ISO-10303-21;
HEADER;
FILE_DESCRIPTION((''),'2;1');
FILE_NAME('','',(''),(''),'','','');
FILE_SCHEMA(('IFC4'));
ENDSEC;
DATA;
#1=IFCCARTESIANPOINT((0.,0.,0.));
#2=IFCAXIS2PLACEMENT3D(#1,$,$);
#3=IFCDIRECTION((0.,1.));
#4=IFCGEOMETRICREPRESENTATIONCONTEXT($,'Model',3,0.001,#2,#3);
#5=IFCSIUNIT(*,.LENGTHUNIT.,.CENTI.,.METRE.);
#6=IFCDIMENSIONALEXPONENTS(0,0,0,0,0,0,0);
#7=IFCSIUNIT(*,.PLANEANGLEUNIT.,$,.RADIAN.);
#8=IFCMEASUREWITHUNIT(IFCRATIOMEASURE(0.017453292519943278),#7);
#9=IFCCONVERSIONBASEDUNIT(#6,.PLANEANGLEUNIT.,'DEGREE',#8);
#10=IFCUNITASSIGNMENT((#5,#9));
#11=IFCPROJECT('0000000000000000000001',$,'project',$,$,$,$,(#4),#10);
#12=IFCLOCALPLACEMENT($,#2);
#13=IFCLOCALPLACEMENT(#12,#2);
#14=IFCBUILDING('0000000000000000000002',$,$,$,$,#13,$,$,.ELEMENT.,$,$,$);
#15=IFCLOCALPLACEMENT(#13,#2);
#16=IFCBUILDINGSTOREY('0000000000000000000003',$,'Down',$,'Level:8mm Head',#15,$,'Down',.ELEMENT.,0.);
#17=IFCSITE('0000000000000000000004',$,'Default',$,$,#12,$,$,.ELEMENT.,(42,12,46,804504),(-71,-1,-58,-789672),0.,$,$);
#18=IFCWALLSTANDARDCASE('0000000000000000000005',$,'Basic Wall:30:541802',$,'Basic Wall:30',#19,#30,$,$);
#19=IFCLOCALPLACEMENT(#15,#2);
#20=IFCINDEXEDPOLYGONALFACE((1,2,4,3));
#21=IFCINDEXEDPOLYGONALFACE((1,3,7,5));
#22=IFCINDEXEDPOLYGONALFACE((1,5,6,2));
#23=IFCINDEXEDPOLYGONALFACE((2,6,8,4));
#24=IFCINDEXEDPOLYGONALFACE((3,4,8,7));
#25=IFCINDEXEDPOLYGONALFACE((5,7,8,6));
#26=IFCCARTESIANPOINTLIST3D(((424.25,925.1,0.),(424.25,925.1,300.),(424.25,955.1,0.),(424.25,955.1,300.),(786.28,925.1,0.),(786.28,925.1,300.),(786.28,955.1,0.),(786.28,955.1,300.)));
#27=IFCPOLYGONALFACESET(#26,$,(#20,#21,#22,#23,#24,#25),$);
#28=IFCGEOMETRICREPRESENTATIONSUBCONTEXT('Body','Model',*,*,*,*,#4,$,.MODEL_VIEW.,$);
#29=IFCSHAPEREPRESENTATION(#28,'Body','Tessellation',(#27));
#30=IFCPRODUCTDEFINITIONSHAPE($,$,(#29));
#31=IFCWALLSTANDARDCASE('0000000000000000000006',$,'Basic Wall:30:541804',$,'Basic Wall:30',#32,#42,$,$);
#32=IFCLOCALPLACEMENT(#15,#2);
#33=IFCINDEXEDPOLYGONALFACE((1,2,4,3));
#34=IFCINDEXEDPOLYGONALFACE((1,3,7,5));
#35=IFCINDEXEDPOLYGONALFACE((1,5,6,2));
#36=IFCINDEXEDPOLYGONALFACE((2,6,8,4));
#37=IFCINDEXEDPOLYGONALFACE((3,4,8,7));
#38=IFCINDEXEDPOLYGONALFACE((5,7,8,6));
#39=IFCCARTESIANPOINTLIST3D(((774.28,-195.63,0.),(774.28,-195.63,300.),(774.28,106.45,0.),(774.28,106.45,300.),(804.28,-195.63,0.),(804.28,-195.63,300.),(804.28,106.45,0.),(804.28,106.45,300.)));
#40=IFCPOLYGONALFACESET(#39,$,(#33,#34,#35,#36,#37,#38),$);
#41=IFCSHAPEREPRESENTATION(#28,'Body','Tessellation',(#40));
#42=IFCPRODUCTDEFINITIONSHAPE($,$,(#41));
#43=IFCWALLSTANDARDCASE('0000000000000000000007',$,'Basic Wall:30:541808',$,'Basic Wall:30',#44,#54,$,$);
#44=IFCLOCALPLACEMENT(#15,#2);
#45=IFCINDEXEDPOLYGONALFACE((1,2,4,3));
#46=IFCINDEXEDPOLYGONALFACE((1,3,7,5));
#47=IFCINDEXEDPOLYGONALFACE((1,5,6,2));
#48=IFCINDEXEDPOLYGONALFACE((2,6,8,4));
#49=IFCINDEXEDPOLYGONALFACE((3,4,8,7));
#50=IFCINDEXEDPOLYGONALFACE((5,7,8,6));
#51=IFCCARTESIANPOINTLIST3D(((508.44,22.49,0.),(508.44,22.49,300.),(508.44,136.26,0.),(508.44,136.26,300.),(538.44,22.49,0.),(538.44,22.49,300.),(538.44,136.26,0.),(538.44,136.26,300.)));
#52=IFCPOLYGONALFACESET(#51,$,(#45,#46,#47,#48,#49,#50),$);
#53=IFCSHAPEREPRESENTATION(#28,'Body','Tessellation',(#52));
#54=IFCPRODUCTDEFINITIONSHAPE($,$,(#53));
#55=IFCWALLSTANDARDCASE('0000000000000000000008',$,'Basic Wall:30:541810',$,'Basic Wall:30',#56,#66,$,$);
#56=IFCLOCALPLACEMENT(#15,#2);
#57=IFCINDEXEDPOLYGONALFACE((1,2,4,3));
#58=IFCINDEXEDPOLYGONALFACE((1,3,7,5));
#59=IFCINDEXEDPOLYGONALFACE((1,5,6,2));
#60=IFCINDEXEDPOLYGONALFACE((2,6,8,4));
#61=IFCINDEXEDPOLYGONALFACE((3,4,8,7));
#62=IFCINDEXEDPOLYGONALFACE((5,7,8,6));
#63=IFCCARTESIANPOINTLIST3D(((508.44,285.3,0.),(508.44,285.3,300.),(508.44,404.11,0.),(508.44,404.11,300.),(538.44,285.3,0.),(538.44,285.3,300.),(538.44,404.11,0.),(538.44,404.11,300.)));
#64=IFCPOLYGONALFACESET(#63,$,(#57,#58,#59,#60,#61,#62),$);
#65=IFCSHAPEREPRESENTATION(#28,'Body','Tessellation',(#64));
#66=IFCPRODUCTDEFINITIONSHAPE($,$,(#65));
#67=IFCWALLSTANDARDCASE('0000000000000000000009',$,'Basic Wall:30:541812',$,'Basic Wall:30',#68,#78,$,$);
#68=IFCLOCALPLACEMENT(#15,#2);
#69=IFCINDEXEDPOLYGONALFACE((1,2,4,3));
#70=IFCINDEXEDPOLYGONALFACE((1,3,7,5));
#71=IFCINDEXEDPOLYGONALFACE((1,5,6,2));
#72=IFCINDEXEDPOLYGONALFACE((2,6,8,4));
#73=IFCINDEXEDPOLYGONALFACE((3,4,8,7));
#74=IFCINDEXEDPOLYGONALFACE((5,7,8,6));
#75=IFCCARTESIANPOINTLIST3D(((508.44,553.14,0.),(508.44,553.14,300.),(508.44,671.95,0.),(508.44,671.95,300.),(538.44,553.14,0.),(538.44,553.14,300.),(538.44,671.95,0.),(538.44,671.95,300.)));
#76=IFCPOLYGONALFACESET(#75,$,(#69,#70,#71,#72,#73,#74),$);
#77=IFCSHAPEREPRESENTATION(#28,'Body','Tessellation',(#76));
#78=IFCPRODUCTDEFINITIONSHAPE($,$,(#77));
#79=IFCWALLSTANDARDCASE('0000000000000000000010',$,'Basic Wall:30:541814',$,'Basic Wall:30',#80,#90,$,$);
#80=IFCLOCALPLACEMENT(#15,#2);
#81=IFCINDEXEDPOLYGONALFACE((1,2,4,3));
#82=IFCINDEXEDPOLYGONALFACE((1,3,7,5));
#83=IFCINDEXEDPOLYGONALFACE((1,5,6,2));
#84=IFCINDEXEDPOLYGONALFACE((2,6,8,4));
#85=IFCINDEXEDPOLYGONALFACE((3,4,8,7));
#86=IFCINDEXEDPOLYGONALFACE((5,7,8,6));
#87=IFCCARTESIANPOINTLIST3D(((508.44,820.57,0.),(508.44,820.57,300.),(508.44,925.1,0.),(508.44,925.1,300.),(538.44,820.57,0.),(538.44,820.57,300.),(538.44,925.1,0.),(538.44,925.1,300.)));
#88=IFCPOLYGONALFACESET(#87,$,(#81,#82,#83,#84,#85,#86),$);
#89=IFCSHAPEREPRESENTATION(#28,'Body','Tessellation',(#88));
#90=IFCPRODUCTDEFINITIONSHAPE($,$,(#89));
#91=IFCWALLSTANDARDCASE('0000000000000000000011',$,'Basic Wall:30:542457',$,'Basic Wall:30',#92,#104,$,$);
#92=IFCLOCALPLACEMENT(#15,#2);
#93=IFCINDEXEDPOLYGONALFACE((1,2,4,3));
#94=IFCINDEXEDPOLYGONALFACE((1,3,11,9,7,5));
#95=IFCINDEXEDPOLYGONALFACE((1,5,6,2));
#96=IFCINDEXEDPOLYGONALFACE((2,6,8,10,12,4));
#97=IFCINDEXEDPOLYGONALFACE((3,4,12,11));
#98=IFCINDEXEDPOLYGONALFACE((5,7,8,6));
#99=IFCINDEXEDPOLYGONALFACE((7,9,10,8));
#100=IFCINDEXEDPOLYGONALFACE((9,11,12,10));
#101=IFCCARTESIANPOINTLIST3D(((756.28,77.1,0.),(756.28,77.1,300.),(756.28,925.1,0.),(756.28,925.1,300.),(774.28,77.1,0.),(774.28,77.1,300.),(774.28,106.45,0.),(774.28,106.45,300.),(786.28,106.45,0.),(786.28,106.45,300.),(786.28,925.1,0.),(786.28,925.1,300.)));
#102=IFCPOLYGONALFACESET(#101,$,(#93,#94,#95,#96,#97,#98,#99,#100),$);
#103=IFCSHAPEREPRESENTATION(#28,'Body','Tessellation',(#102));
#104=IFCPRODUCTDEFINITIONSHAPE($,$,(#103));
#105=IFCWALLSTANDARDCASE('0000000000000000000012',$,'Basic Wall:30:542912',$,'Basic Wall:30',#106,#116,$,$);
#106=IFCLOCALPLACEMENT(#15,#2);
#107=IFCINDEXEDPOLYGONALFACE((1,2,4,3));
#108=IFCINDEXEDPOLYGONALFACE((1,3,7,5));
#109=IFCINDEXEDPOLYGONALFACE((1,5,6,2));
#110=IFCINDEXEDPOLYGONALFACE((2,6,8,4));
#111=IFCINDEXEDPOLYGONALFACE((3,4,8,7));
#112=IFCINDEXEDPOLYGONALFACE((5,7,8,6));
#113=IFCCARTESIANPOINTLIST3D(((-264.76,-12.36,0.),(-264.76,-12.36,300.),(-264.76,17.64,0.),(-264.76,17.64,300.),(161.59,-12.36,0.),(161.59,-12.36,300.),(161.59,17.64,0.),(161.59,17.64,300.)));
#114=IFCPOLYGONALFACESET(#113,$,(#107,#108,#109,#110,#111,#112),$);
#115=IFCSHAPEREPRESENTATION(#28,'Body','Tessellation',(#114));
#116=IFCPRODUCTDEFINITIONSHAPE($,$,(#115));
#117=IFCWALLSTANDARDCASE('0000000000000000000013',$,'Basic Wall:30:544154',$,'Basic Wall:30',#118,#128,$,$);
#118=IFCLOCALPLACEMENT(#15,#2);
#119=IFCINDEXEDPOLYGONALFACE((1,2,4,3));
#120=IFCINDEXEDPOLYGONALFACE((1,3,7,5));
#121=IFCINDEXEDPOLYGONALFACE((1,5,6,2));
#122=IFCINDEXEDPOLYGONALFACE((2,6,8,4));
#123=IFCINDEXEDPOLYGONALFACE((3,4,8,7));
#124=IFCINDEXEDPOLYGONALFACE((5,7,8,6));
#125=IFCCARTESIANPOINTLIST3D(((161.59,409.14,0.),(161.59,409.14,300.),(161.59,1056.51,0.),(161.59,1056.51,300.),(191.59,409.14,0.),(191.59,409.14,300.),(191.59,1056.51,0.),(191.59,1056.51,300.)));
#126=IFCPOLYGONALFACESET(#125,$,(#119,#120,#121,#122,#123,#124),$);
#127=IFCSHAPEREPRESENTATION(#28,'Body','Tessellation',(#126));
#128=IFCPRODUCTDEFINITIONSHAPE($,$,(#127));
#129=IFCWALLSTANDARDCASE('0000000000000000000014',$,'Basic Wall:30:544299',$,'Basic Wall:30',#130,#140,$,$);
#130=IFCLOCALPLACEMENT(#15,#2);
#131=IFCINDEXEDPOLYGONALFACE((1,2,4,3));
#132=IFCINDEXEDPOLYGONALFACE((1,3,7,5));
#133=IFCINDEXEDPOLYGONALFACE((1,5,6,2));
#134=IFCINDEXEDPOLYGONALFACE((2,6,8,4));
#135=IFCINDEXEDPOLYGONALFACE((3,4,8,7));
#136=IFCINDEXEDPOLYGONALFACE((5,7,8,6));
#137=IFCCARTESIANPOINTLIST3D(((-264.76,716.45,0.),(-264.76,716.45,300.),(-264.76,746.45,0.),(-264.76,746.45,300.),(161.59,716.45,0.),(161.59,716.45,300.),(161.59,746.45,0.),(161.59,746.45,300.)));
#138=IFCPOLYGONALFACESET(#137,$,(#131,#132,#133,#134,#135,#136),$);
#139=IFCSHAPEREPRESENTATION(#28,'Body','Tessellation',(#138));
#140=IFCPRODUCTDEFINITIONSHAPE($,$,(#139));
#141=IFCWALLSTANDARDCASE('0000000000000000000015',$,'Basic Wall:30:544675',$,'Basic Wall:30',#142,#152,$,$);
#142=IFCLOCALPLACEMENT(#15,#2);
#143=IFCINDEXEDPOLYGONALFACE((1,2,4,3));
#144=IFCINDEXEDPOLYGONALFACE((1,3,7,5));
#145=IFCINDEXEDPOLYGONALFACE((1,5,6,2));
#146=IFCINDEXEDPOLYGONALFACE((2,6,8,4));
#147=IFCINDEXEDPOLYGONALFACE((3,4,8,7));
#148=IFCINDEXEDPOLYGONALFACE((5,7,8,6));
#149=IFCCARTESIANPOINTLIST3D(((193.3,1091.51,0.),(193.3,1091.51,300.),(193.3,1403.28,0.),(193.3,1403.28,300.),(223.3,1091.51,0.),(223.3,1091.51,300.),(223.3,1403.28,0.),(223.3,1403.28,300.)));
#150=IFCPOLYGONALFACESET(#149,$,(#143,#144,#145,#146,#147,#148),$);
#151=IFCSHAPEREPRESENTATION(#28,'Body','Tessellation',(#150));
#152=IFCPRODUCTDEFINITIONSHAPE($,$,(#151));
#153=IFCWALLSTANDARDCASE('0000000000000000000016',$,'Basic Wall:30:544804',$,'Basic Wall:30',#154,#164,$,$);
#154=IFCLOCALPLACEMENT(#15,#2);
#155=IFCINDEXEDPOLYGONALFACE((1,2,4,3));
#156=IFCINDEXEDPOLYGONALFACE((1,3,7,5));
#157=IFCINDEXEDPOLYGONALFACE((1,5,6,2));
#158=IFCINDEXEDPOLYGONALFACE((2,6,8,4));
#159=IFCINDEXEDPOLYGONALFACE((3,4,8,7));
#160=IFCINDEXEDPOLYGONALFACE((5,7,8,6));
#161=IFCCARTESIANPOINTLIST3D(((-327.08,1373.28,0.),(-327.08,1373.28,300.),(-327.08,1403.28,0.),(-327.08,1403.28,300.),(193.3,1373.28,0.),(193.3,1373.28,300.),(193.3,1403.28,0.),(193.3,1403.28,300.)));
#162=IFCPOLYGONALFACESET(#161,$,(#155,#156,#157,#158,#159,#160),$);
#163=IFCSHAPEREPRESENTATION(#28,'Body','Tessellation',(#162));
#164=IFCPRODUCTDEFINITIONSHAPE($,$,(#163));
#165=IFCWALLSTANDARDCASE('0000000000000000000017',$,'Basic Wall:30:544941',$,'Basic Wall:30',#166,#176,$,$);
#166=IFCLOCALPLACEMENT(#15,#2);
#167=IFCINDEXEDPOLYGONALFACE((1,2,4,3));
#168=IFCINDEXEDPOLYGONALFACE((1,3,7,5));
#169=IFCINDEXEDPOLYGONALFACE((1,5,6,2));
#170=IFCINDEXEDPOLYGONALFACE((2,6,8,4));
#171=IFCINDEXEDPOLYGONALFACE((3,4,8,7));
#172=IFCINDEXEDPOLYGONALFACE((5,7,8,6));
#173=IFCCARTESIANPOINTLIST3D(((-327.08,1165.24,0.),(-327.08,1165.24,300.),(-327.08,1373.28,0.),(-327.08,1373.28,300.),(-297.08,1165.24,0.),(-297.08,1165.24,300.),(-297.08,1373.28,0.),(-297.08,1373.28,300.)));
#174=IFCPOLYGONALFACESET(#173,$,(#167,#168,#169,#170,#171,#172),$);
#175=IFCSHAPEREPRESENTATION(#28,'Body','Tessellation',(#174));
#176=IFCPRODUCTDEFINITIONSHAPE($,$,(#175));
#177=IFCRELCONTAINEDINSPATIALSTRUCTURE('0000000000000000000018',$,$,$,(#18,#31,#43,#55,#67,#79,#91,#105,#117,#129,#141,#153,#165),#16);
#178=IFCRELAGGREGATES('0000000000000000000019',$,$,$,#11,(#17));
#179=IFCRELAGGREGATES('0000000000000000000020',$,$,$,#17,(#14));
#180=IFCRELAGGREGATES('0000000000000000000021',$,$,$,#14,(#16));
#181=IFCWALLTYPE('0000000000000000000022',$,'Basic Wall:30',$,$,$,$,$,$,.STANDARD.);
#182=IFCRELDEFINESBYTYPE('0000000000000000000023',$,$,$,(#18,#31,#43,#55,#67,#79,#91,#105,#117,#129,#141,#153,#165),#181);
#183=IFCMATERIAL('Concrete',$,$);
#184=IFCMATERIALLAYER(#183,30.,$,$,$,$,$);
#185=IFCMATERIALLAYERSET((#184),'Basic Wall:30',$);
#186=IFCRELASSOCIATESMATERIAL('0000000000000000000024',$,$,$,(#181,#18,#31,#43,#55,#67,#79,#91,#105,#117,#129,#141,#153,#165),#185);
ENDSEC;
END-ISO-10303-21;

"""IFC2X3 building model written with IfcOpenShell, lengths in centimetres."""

from ifc_helpers import new_model, entity, si_unit, converted_unit, direction, frame, frame_2d, origin, place, context, subcontext, project, spatial, polyline, rectangle, extrude, clip, bounded_halfspace, material, layer, layer_set, layer_usage, type_object, element, save


model = new_model("IFC2X3")

# Units and contexts
model_context = context("Model", 3, precision=0.001, world=origin(), true_north=direction((0.0, 1.0)))
body_context = subcontext(model_context, "Body", "Model", "MODEL_VIEW")
ifc_project = project(units=[si_unit("LENGTHUNIT", "METRE", prefix="CENTI"), converted_unit("PLANEANGLEUNIT", "DEGREE", entity("IfcRatioMeasure", 0.017453292519943278), si_unit("PLANEANGLEUNIT", "RADIAN"), dimensions=[0, 0, 0, 0, 0, 0, 0])], contexts=[model_context])

# Site, building, storey
site_placement = place(None, origin())
site = spatial("IfcSite", under=ifc_project, at=site_placement, Name="Default", CompositionType="ELEMENT", RefLatitude=(42, 12, 46, 804504), RefLongitude=(-71, -1, -58, -789672), RefElevation=0.0)
building_placement = place(site_placement, origin())
building = spatial("IfcBuilding", under=site, at=building_placement, CompositionType="ELEMENT")
storey_placement = place(building_placement, origin())
storey = spatial("IfcBuildingStorey", under=building, at=storey_placement, Name="Down", ObjectType="Level:8mm Head", LongName="Down", CompositionType="ELEMENT", Elevation=0.0)

# Shared definitions
ifc_material = material(Name="Concrete")

# Walls
ifc_layer_1 = layer(ifc_material, 30.0)
ifc_layer_set_1 = layer_set([ifc_layer_1], Name="Basic Wall:30")
wall_type_1 = type_object("IfcWallType", Name="Basic Wall:30", PredefinedType="STANDARD", material=ifc_layer_set_1)
ifc_layer_usage_1 = layer_usage(ifc_layer_set_1, "AXIS2", "POSITIVE", -15.0)
wall_1_placement = place(storey_placement, frame((424.25, 940.1, 0.0)))
element("IfcWallStandardCase", 1, at=wall_1_placement, inside=storey, type_object=wall_type_1, material=ifc_layer_usage_1, Name="Basic Wall:30:541802", ObjectType="Basic Wall:30", context=body_context, shape_type="SweptSolid", body=[
    extrude(rectangle(XDim=362.04, YDim=30.0, at=frame_2d((181.02, 0.0), x_axis=(-1.0, 0.0))), origin(), (0.0, 0.0, 1.0), 300.0),
])
ifc_layer_usage_2 = layer_usage(ifc_layer_set_1, "AXIS2", "NEGATIVE", 15.0)
wall_2_placement = place(storey_placement, frame((789.28, 106.45, 0.0), z_axis=(0.0, 0.0, 1.0), x_axis=(0.0, -1.0, 0.0)))
element("IfcWallStandardCase", 2, at=wall_2_placement, inside=storey, type_object=wall_type_1, material=ifc_layer_usage_2, Name="Basic Wall:30:541804", ObjectType="Basic Wall:30", context=body_context, shape_type="SweptSolid", body=[
    extrude(rectangle(XDim=302.08, YDim=30.0, at=frame_2d((151.04, 0.0), x_axis=(-1.0, 0.0))), origin(), (0.0, 0.0, 1.0), 300.0),
])
ifc_layer_usage_3 = layer_usage(ifc_layer_set_1, "AXIS2", "POSITIVE", -15.0)
wall_3_placement = place(storey_placement, frame((523.44, 22.49, 0.0), z_axis=(0.0, 0.0, 1.0), x_axis=(0.0, 1.0, 0.0)))
element("IfcWallStandardCase", 3, at=wall_3_placement, inside=storey, type_object=wall_type_1, material=ifc_layer_usage_3, Name="Basic Wall:30:541808", ObjectType="Basic Wall:30", context=body_context, shape_type="SweptSolid", body=[
    extrude(rectangle(XDim=113.77, YDim=30.0, at=frame_2d((56.89, 0.0), x_axis=(-1.0, 0.0))), origin(), (0.0, 0.0, 1.0), 300.0),
])
ifc_layer_usage_4 = layer_usage(ifc_layer_set_1, "AXIS2", "POSITIVE", -15.0)
wall_4_placement = place(storey_placement, frame((523.44, 285.3, 0.0), z_axis=(0.0, 0.0, 1.0), x_axis=(0.0, 1.0, 0.0)))
element("IfcWallStandardCase", 4, at=wall_4_placement, inside=storey, type_object=wall_type_1, material=ifc_layer_usage_4, Name="Basic Wall:30:541810", ObjectType="Basic Wall:30", context=body_context, shape_type="SweptSolid", body=[
    extrude(rectangle(XDim=118.81, YDim=30.0, at=frame_2d((59.4, 0.0), x_axis=(-1.0, 0.0))), origin(), (0.0, 0.0, 1.0), 300.0),
])
ifc_layer_usage_5 = layer_usage(ifc_layer_set_1, "AXIS2", "POSITIVE", -15.0)
wall_5_placement = place(storey_placement, frame((523.44, 553.14, 0.0), z_axis=(0.0, 0.0, 1.0), x_axis=(0.0, 1.0, 0.0)))
element("IfcWallStandardCase", 5, at=wall_5_placement, inside=storey, type_object=wall_type_1, material=ifc_layer_usage_5, Name="Basic Wall:30:541812", ObjectType="Basic Wall:30", context=body_context, shape_type="SweptSolid", body=[
    extrude(rectangle(XDim=118.81, YDim=30.0, at=frame_2d((59.4, 0.0), x_axis=(-1.0, 0.0))), origin(), (0.0, 0.0, 1.0), 300.0),
])
ifc_layer_usage_6 = layer_usage(ifc_layer_set_1, "AXIS2", "POSITIVE", -15.0)
wall_6_placement = place(storey_placement, frame((523.44, 820.57, 0.0), z_axis=(0.0, 0.0, 1.0), x_axis=(0.0, 1.0, 0.0)))
element("IfcWallStandardCase", 6, at=wall_6_placement, inside=storey, type_object=wall_type_1, material=ifc_layer_usage_6, Name="Basic Wall:30:541814", ObjectType="Basic Wall:30", context=body_context, shape_type="SweptSolid", body=[
    extrude(rectangle(XDim=104.54, YDim=30.0, at=frame_2d((52.27, 0.0), x_axis=(-1.0, 0.0))), origin(), (0.0, 0.0, 1.0), 300.0),
])
ifc_layer_usage_7 = layer_usage(ifc_layer_set_1, "AXIS2", "NEGATIVE", 15.0)
wall_7_placement = place(storey_placement, frame((771.28, 925.1, 0.0), z_axis=(0.0, 0.0, 1.0), x_axis=(0.0, -1.0, 0.0)))
element("IfcWallStandardCase", 7, at=wall_7_placement, inside=storey, type_object=wall_type_1, material=ifc_layer_usage_7, Name="Basic Wall:30:542457", ObjectType="Basic Wall:30", context=body_context, shape_type="Clipping", body=[
    clip(clip(extrude(rectangle(XDim=848.0, YDim=30.0, at=frame_2d((424.0, 0.0), x_axis=(-1.0, 0.0))), origin(), (0.0, 0.0, 1.0), 300.0), bounded_halfspace(frame((818.65, 3.0, 0.0), z_axis=(0.0, -1.0, 0.0), x_axis=(1.0, 0.0, 0.0)), True, frame((818.65, 3.0, 0.0), z_axis=(0.0, -1.0, 0.0), x_axis=(1.0, 0.0, 0.0)), polyline([(0.0, 0.0), (29.35, 0.0), (29.35, 300.0), (0.0, 300.0), (0.0, 0.0)]))), bounded_halfspace(frame((818.65, 3.0, 300.0), z_axis=(-1.0, 0.0, 0.0), x_axis=(0.0, 1.0, 0.0)), True, frame((818.65, 3.0, 300.0), z_axis=(-1.0, 0.0, 0.0), x_axis=(0.0, 1.0, 0.0)), polyline([(0.0, 0.0), (12.0, 0.0), (12.0, 30.0), (12.0, 300.0), (0.0, 300.0), (0.0, 0.0)]))),
])
ifc_layer_usage_8 = layer_usage(ifc_layer_set_1, "AXIS2", "POSITIVE", -15.0)
wall_8_placement = place(storey_placement, frame((-264.76, 2.64, 0.0)))
element("IfcWallStandardCase", 8, at=wall_8_placement, inside=storey, type_object=wall_type_1, material=ifc_layer_usage_8, Name="Basic Wall:30:542912", ObjectType="Basic Wall:30", context=body_context, shape_type="SweptSolid", body=[
    extrude(rectangle(XDim=426.35, YDim=30.0, at=frame_2d((213.17, 0.0), x_axis=(-1.0, 0.0))), origin(), (0.0, 0.0, 1.0), 300.0),
])
ifc_layer_usage_9 = layer_usage(ifc_layer_set_1, "AXIS2", "NEGATIVE", 15.0)
wall_9_placement = place(storey_placement, frame((176.59, 409.14, 0.0), z_axis=(0.0, 0.0, 1.0), x_axis=(0.0, 1.0, 0.0)))
element("IfcWallStandardCase", 9, at=wall_9_placement, inside=storey, type_object=wall_type_1, material=ifc_layer_usage_9, Name="Basic Wall:30:544154", ObjectType="Basic Wall:30", context=body_context, shape_type="SweptSolid", body=[
    extrude(rectangle(XDim=647.36, YDim=30.0, at=frame_2d((323.68, 0.0), x_axis=(-1.0, 0.0))), origin(), (0.0, 0.0, 1.0), 300.0),
])
ifc_layer_usage_10 = layer_usage(ifc_layer_set_1, "AXIS2", "POSITIVE", -15.0)
wall_10_placement = place(storey_placement, frame((-264.76, 731.45, 0.0)))
element("IfcWallStandardCase", 10, at=wall_10_placement, inside=storey, type_object=wall_type_1, material=ifc_layer_usage_10, Name="Basic Wall:30:544299", ObjectType="Basic Wall:30", context=body_context, shape_type="SweptSolid", body=[
    extrude(rectangle(XDim=426.35, YDim=30.0, at=frame_2d((213.17, 0.0), x_axis=(-1.0, 0.0))), origin(), (0.0, 0.0, 1.0), 300.0),
])
ifc_layer_usage_11 = layer_usage(ifc_layer_set_1, "AXIS2", "POSITIVE", -15.0)
wall_11_placement = place(storey_placement, frame((208.3, 1091.51, 0.0), z_axis=(0.0, 0.0, 1.0), x_axis=(0.0, 1.0, 0.0)))
element("IfcWallStandardCase", 11, at=wall_11_placement, inside=storey, type_object=wall_type_1, material=ifc_layer_usage_11, Name="Basic Wall:30:544675", ObjectType="Basic Wall:30", context=body_context, shape_type="SweptSolid", body=[
    extrude(rectangle(XDim=311.77, YDim=30.0, at=frame_2d((155.89, 0.0), x_axis=(-1.0, 0.0))), origin(), (0.0, 0.0, 1.0), 300.0),
])
ifc_layer_usage_12 = layer_usage(ifc_layer_set_1, "AXIS2", "POSITIVE", -15.0)
wall_12_placement = place(storey_placement, frame((193.3, 1388.28, 0.0), z_axis=(0.0, 0.0, 1.0), x_axis=(-1.0, 0.0, 0.0)))
element("IfcWallStandardCase", 12, at=wall_12_placement, inside=storey, type_object=wall_type_1, material=ifc_layer_usage_12, Name="Basic Wall:30:544804", ObjectType="Basic Wall:30", context=body_context, shape_type="SweptSolid", body=[
    extrude(rectangle(XDim=520.39, YDim=30.0, at=frame_2d((260.19, 0.0), x_axis=(-1.0, 0.0))), origin(), (0.0, 0.0, 1.0), 300.0),
])
ifc_layer_usage_13 = layer_usage(ifc_layer_set_1, "AXIS2", "POSITIVE", -15.0)
wall_13_placement = place(storey_placement, frame((-312.08, 1373.28, 0.0), z_axis=(0.0, 0.0, 1.0), x_axis=(0.0, -1.0, 0.0)))
element("IfcWallStandardCase", 13, at=wall_13_placement, inside=storey, type_object=wall_type_1, material=ifc_layer_usage_13, Name="Basic Wall:30:544941", ObjectType="Basic Wall:30", context=body_context, shape_type="SweptSolid", body=[
    extrude(rectangle(XDim=208.04, YDim=30.0, at=frame_2d((104.02, 0.0), x_axis=(-1.0, 0.0))), origin(), (0.0, 0.0, 1.0), 300.0),
])

save(model, "model.ifc")
